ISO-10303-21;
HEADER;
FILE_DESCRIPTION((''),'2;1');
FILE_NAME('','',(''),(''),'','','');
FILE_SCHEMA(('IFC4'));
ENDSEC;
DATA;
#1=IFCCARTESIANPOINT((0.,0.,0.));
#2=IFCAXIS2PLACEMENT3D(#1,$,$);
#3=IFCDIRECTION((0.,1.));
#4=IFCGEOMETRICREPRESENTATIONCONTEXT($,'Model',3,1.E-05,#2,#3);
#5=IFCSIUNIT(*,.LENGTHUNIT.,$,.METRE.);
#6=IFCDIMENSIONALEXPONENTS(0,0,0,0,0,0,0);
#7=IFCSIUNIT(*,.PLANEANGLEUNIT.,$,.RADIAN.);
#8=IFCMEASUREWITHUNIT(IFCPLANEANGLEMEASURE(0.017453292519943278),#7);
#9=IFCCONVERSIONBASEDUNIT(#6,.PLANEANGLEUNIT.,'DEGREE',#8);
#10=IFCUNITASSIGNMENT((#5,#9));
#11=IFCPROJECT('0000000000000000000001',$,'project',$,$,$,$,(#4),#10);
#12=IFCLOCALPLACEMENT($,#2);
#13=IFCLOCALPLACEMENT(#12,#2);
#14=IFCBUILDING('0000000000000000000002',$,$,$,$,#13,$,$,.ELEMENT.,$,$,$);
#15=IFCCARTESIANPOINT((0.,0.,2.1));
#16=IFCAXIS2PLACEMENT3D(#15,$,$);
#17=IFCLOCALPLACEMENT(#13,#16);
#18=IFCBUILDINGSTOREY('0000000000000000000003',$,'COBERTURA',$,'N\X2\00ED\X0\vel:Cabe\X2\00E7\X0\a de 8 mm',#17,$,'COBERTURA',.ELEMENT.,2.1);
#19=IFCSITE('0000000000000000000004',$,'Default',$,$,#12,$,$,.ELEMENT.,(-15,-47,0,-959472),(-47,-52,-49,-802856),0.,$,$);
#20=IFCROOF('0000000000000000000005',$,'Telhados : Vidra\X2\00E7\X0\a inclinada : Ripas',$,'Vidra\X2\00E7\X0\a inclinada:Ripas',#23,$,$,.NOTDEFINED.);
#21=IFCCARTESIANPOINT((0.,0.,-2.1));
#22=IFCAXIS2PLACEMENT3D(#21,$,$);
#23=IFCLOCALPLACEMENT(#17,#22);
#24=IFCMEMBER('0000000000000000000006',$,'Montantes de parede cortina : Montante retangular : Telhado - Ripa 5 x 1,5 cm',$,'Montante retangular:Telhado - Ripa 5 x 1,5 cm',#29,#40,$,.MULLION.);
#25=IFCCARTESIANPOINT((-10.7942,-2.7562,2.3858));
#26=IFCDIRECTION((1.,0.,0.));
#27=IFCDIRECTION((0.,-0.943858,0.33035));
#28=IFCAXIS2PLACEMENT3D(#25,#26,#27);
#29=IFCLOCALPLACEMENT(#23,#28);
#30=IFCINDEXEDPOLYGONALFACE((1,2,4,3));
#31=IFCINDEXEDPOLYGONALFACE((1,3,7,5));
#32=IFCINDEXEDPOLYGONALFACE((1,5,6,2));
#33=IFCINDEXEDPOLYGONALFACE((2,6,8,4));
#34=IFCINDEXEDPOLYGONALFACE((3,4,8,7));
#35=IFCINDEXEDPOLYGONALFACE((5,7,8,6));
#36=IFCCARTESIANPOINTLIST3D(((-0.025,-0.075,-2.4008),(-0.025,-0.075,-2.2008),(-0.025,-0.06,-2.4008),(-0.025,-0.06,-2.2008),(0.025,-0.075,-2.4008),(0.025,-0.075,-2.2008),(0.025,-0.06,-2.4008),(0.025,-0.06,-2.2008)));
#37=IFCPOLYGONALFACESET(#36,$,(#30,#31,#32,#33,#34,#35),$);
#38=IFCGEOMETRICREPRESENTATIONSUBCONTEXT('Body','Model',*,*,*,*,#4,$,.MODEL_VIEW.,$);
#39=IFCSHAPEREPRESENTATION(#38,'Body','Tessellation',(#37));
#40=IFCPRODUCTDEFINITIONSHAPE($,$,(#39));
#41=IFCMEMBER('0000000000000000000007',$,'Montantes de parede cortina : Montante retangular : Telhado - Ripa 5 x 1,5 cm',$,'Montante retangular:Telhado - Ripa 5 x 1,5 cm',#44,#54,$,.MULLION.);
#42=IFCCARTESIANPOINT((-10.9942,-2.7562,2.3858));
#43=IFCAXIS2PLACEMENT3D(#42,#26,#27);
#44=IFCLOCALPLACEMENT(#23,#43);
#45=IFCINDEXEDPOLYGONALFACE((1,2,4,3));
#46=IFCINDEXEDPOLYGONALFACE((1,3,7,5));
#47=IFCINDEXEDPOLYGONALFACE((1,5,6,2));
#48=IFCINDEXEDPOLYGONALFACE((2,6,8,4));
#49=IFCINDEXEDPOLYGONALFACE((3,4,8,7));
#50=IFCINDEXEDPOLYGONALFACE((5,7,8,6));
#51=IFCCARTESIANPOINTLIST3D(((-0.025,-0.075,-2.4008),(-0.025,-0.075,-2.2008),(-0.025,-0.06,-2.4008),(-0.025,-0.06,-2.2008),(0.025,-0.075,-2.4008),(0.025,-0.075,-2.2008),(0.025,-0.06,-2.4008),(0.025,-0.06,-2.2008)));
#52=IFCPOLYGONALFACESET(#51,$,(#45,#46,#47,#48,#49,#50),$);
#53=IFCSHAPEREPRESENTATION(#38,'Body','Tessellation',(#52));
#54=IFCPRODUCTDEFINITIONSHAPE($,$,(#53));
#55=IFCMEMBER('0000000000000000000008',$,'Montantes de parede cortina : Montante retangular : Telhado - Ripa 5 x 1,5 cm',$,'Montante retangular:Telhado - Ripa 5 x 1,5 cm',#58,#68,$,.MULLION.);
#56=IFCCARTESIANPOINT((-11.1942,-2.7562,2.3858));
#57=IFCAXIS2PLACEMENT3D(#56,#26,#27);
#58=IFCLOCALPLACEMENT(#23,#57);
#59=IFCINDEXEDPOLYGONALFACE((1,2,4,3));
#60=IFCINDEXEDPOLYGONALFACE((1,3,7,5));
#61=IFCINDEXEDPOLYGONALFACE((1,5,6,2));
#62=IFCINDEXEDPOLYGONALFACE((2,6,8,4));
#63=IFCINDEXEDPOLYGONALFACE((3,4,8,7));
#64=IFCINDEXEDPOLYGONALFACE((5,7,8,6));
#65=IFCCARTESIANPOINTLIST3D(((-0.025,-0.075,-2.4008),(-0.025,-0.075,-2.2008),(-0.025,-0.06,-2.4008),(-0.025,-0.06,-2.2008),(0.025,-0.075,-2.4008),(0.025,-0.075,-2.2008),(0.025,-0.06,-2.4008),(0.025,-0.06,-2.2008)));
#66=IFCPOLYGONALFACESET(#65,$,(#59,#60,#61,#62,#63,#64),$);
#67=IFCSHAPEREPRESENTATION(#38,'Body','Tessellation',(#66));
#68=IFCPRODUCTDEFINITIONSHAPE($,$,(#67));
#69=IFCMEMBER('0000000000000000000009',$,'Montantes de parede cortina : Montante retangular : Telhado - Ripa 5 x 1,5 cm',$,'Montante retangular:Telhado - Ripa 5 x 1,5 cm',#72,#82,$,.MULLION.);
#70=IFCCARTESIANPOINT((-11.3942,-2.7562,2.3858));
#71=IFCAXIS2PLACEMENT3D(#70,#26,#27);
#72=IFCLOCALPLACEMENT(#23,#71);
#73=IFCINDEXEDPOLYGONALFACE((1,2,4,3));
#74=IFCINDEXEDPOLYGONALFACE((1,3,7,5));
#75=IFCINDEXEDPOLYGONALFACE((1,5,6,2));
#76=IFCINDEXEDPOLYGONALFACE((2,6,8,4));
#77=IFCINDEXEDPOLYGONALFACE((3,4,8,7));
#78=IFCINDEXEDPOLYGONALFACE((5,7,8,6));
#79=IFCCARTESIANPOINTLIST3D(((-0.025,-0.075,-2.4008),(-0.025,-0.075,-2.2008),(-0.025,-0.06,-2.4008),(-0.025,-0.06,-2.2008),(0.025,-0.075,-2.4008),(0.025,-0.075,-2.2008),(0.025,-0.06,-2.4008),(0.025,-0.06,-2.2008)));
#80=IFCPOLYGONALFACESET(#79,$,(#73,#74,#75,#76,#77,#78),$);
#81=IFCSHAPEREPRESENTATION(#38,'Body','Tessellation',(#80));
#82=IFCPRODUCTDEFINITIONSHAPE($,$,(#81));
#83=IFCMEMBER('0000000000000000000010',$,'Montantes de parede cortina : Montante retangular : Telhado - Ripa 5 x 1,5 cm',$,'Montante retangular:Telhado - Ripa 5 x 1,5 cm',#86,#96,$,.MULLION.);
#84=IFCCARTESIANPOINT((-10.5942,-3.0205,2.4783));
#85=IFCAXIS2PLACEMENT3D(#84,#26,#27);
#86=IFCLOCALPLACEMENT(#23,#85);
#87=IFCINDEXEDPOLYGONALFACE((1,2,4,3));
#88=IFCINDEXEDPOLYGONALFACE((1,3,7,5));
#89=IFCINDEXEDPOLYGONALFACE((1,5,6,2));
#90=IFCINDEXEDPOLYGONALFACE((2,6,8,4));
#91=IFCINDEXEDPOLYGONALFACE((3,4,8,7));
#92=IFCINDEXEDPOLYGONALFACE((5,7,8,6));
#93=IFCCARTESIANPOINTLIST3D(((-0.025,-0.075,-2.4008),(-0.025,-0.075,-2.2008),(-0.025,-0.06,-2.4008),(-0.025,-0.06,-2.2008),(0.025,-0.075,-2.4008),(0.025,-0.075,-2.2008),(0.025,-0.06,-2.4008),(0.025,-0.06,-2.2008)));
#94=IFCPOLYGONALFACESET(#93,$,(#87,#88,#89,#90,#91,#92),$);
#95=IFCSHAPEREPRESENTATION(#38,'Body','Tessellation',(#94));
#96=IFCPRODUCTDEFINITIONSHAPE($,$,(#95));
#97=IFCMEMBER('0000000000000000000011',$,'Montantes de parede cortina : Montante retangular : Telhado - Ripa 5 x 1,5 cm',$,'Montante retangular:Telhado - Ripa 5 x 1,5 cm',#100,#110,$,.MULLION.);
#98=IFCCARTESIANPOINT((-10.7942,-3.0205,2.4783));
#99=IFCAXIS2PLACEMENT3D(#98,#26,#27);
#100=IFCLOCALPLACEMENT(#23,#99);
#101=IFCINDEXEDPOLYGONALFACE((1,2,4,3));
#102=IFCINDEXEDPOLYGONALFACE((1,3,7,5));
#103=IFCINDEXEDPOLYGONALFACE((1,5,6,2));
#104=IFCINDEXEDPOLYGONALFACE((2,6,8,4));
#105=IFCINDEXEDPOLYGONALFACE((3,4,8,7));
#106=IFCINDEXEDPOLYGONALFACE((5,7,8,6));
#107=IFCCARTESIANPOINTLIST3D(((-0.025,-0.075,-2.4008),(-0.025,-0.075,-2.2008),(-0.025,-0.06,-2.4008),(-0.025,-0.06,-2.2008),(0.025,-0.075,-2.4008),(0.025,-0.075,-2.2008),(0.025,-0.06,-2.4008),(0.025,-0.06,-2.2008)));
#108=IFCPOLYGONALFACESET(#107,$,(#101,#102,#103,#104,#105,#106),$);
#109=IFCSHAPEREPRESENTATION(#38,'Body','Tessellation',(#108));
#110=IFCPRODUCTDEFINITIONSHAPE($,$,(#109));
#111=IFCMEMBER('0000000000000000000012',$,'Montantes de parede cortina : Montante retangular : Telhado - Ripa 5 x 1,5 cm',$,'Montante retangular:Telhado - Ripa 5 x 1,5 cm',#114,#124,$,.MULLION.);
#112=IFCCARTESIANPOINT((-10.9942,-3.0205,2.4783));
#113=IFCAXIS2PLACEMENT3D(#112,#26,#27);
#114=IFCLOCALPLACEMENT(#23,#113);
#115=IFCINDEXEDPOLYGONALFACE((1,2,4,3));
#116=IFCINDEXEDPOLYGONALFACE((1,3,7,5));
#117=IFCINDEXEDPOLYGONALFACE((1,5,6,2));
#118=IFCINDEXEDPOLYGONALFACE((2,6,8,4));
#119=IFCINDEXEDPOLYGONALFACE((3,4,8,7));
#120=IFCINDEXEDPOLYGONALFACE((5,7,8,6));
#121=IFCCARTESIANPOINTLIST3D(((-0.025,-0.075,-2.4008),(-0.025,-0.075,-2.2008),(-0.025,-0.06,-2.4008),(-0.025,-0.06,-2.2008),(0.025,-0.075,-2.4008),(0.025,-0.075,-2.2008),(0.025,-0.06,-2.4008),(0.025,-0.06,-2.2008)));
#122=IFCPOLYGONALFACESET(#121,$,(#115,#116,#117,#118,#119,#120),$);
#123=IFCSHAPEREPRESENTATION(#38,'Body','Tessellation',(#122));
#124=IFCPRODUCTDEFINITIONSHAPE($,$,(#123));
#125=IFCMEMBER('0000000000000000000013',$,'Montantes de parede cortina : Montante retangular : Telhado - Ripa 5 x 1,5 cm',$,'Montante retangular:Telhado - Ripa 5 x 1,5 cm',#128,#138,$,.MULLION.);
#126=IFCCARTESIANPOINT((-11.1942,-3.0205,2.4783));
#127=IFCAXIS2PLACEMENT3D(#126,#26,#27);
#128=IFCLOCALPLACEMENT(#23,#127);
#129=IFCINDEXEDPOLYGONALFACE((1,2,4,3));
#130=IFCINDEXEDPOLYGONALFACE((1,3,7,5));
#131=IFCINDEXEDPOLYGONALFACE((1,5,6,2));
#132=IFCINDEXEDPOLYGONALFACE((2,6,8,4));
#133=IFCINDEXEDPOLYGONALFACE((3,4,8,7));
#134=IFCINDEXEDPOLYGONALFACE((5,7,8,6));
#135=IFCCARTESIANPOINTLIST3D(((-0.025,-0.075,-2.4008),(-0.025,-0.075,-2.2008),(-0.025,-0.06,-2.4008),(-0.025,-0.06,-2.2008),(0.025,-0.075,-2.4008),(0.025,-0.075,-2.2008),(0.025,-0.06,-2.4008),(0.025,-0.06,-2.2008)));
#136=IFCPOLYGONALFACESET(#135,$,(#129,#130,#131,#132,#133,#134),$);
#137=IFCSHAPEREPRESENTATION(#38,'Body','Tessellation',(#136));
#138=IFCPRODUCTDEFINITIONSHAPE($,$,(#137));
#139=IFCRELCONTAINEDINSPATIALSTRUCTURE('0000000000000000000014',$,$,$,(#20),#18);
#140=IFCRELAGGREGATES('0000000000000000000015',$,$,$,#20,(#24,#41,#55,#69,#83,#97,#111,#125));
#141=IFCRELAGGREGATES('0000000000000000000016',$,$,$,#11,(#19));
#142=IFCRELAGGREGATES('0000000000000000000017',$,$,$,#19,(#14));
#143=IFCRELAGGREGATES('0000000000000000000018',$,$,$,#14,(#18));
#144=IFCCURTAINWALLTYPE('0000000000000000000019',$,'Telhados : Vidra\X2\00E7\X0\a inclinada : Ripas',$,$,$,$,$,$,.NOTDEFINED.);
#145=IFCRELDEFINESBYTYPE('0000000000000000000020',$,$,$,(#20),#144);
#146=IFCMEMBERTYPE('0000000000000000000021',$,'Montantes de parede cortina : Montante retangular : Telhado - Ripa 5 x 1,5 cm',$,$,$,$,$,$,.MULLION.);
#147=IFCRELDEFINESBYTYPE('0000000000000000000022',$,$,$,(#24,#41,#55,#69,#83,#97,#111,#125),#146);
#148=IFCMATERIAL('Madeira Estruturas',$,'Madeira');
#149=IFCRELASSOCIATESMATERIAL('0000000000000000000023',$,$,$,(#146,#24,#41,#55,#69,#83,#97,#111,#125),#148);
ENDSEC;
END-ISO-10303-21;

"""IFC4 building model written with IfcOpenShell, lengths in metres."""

from ifc_helpers import new_model, entity, si_unit, converted_unit, direction, frame, origin, place, context, subcontext, project, spatial, indexed_curve, outline, extrude, source, transform, mapped, material, type_object, type_shapes, element, aggregate, save


model = new_model("IFC4")

# Units and contexts
model_context = context("Model", 3, precision=1e-05, world=origin(), true_north=direction((0.0, 1.0)))
body_context = subcontext(model_context, "Body", "Model", "MODEL_VIEW")
ifc_project = project(units=[si_unit("LENGTHUNIT", "METRE"), converted_unit("PLANEANGLEUNIT", "DEGREE", entity("IfcPlaneAngleMeasure", 0.017453292519943278), si_unit("PLANEANGLEUNIT", "RADIAN"), dimensions=[0, 0, 0, 0, 0, 0, 0])], contexts=[model_context])

# Site, building, storey
site_placement = place(None, origin())
site = spatial("IfcSite", under=ifc_project, at=site_placement, Name="Default", CompositionType="ELEMENT", RefLatitude=(-15, -47, 0, -959472), RefLongitude=(-47, -52, -49, -802856), RefElevation=0.0)
building_placement = place(site_placement, origin())
building = spatial("IfcBuilding", under=site, at=building_placement, CompositionType="ELEMENT")
storey_placement = place(building_placement, frame((0.0, 0.0, 2.1)))
storey = spatial("IfcBuildingStorey", under=building, at=storey_placement, Name="COBERTURA", ObjectType="Nível:Cabeça de 8 mm", LongName="COBERTURA", CompositionType="ELEMENT", Elevation=2.1)

# Roof, members
curtain_wall_type = type_object("IfcCurtainWallType", Name="Telhados : Vidraça inclinada : Ripas", PredefinedType="NOTDEFINED")
roof_placement = place(storey_placement, frame((0.0, 0.0, -2.1)))
roof = element("IfcRoof", 1, at=roof_placement, inside=storey, type_object=curtain_wall_type, Name="Telhados : Vidraça inclinada : Ripas", ObjectType="Vidraça inclinada:Ripas", PredefinedType="NOTDEFINED")
ifc_material = material(Name="Madeira Estruturas", Category="Madeira")
member_type = type_object("IfcMemberType", Name="Montantes de parede cortina : Montante retangular : Telhado - Ripa 5 x 1,5 cm", PredefinedType="MULLION", material=ifc_material)
shared_shape = source(origin(), body_context, "Body", "SweptSolid", [
    extrude(outline(indexed_curve([(-0.025, -0.0075), (0.025, -0.0075), (0.025, 0.0075), (-0.025, 0.0075), (-0.025, -0.0075)], self_intersect=False)), frame((0.0, -0.0675, -2.4008), z_axis=(0.0, 0.0, 1.0), x_axis=(-1.0, 0.0, 0.0)), (0.0, 0.0, 1.0), 0.2),
])
type_shapes(member_type, [shared_shape])
member_1_placement = place(roof_placement, frame((-10.7942, -2.7562, 2.3858), z_axis=(1.0, 0.0, 0.0), x_axis=(0.0, -0.943858, 0.33035)))
member_1 = element("IfcMember", 2, at=member_1_placement, type_object=member_type, material=ifc_material, Name="Montantes de parede cortina : Montante retangular : Telhado - Ripa 5 x 1,5 cm", ObjectType="Montante retangular:Telhado - Ripa 5 x 1,5 cm", PredefinedType="MULLION", context=body_context, shape_type="MappedRepresentation", body=[
    mapped(shared_shape, transform((0.0, 0.0, 0.0), scale=1.0)),
])
member_2_placement = place(roof_placement, frame((-10.9942, -2.7562, 2.3858), z_axis=(1.0, 0.0, 0.0), x_axis=(0.0, -0.943858, 0.33035)))
member_2 = element("IfcMember", 3, at=member_2_placement, type_object=member_type, material=ifc_material, Name="Montantes de parede cortina : Montante retangular : Telhado - Ripa 5 x 1,5 cm", ObjectType="Montante retangular:Telhado - Ripa 5 x 1,5 cm", PredefinedType="MULLION", context=body_context, shape_type="MappedRepresentation", body=[
    mapped(shared_shape, transform((0.0, 0.0, 0.0), scale=1.0)),
])
member_3_placement = place(roof_placement, frame((-11.1942, -2.7562, 2.3858), z_axis=(1.0, 0.0, 0.0), x_axis=(0.0, -0.943858, 0.33035)))
member_3 = element("IfcMember", 4, at=member_3_placement, type_object=member_type, material=ifc_material, Name="Montantes de parede cortina : Montante retangular : Telhado - Ripa 5 x 1,5 cm", ObjectType="Montante retangular:Telhado - Ripa 5 x 1,5 cm", PredefinedType="MULLION", context=body_context, shape_type="MappedRepresentation", body=[
    mapped(shared_shape, transform((0.0, 0.0, 0.0), scale=1.0)),
])
member_4_placement = place(roof_placement, frame((-11.3942, -2.7562, 2.3858), z_axis=(1.0, 0.0, 0.0), x_axis=(0.0, -0.943858, 0.33035)))
member_4 = element("IfcMember", 5, at=member_4_placement, type_object=member_type, material=ifc_material, Name="Montantes de parede cortina : Montante retangular : Telhado - Ripa 5 x 1,5 cm", ObjectType="Montante retangular:Telhado - Ripa 5 x 1,5 cm", PredefinedType="MULLION", context=body_context, shape_type="MappedRepresentation", body=[
    mapped(shared_shape, transform((0.0, 0.0, 0.0), scale=1.0)),
])
member_5_placement = place(roof_placement, frame((-10.5942, -3.0205, 2.4783), z_axis=(1.0, 0.0, 0.0), x_axis=(0.0, -0.943858, 0.33035)))
member_5 = element("IfcMember", 6, at=member_5_placement, type_object=member_type, material=ifc_material, Name="Montantes de parede cortina : Montante retangular : Telhado - Ripa 5 x 1,5 cm", ObjectType="Montante retangular:Telhado - Ripa 5 x 1,5 cm", PredefinedType="MULLION", context=body_context, shape_type="MappedRepresentation", body=[
    mapped(shared_shape, transform((0.0, 0.0, 0.0), scale=1.0)),
])
member_6_placement = place(roof_placement, frame((-10.7942, -3.0205, 2.4783), z_axis=(1.0, 0.0, 0.0), x_axis=(0.0, -0.943858, 0.33035)))
member_6 = element("IfcMember", 7, at=member_6_placement, type_object=member_type, material=ifc_material, Name="Montantes de parede cortina : Montante retangular : Telhado - Ripa 5 x 1,5 cm", ObjectType="Montante retangular:Telhado - Ripa 5 x 1,5 cm", PredefinedType="MULLION", context=body_context, shape_type="MappedRepresentation", body=[
    mapped(shared_shape, transform((0.0, 0.0, 0.0), scale=1.0)),
])
member_7_placement = place(roof_placement, frame((-10.9942, -3.0205, 2.4783), z_axis=(1.0, 0.0, 0.0), x_axis=(0.0, -0.943858, 0.33035)))
member_7 = element("IfcMember", 8, at=member_7_placement, type_object=member_type, material=ifc_material, Name="Montantes de parede cortina : Montante retangular : Telhado - Ripa 5 x 1,5 cm", ObjectType="Montante retangular:Telhado - Ripa 5 x 1,5 cm", PredefinedType="MULLION", context=body_context, shape_type="MappedRepresentation", body=[
    mapped(shared_shape, transform((0.0, 0.0, 0.0), scale=1.0)),
])
member_8_placement = place(roof_placement, frame((-11.1942, -3.0205, 2.4783), z_axis=(1.0, 0.0, 0.0), x_axis=(0.0, -0.943858, 0.33035)))
member_8 = element("IfcMember", 9, at=member_8_placement, type_object=member_type, material=ifc_material, Name="Montantes de parede cortina : Montante retangular : Telhado - Ripa 5 x 1,5 cm", ObjectType="Montante retangular:Telhado - Ripa 5 x 1,5 cm", PredefinedType="MULLION", context=body_context, shape_type="MappedRepresentation", body=[
    mapped(shared_shape, transform((0.0, 0.0, 0.0), scale=1.0)),
])
aggregate(roof, [member_1, member_2, member_3, member_4, member_5, member_6, member_7, member_8])

save(model, "model.ifc")
